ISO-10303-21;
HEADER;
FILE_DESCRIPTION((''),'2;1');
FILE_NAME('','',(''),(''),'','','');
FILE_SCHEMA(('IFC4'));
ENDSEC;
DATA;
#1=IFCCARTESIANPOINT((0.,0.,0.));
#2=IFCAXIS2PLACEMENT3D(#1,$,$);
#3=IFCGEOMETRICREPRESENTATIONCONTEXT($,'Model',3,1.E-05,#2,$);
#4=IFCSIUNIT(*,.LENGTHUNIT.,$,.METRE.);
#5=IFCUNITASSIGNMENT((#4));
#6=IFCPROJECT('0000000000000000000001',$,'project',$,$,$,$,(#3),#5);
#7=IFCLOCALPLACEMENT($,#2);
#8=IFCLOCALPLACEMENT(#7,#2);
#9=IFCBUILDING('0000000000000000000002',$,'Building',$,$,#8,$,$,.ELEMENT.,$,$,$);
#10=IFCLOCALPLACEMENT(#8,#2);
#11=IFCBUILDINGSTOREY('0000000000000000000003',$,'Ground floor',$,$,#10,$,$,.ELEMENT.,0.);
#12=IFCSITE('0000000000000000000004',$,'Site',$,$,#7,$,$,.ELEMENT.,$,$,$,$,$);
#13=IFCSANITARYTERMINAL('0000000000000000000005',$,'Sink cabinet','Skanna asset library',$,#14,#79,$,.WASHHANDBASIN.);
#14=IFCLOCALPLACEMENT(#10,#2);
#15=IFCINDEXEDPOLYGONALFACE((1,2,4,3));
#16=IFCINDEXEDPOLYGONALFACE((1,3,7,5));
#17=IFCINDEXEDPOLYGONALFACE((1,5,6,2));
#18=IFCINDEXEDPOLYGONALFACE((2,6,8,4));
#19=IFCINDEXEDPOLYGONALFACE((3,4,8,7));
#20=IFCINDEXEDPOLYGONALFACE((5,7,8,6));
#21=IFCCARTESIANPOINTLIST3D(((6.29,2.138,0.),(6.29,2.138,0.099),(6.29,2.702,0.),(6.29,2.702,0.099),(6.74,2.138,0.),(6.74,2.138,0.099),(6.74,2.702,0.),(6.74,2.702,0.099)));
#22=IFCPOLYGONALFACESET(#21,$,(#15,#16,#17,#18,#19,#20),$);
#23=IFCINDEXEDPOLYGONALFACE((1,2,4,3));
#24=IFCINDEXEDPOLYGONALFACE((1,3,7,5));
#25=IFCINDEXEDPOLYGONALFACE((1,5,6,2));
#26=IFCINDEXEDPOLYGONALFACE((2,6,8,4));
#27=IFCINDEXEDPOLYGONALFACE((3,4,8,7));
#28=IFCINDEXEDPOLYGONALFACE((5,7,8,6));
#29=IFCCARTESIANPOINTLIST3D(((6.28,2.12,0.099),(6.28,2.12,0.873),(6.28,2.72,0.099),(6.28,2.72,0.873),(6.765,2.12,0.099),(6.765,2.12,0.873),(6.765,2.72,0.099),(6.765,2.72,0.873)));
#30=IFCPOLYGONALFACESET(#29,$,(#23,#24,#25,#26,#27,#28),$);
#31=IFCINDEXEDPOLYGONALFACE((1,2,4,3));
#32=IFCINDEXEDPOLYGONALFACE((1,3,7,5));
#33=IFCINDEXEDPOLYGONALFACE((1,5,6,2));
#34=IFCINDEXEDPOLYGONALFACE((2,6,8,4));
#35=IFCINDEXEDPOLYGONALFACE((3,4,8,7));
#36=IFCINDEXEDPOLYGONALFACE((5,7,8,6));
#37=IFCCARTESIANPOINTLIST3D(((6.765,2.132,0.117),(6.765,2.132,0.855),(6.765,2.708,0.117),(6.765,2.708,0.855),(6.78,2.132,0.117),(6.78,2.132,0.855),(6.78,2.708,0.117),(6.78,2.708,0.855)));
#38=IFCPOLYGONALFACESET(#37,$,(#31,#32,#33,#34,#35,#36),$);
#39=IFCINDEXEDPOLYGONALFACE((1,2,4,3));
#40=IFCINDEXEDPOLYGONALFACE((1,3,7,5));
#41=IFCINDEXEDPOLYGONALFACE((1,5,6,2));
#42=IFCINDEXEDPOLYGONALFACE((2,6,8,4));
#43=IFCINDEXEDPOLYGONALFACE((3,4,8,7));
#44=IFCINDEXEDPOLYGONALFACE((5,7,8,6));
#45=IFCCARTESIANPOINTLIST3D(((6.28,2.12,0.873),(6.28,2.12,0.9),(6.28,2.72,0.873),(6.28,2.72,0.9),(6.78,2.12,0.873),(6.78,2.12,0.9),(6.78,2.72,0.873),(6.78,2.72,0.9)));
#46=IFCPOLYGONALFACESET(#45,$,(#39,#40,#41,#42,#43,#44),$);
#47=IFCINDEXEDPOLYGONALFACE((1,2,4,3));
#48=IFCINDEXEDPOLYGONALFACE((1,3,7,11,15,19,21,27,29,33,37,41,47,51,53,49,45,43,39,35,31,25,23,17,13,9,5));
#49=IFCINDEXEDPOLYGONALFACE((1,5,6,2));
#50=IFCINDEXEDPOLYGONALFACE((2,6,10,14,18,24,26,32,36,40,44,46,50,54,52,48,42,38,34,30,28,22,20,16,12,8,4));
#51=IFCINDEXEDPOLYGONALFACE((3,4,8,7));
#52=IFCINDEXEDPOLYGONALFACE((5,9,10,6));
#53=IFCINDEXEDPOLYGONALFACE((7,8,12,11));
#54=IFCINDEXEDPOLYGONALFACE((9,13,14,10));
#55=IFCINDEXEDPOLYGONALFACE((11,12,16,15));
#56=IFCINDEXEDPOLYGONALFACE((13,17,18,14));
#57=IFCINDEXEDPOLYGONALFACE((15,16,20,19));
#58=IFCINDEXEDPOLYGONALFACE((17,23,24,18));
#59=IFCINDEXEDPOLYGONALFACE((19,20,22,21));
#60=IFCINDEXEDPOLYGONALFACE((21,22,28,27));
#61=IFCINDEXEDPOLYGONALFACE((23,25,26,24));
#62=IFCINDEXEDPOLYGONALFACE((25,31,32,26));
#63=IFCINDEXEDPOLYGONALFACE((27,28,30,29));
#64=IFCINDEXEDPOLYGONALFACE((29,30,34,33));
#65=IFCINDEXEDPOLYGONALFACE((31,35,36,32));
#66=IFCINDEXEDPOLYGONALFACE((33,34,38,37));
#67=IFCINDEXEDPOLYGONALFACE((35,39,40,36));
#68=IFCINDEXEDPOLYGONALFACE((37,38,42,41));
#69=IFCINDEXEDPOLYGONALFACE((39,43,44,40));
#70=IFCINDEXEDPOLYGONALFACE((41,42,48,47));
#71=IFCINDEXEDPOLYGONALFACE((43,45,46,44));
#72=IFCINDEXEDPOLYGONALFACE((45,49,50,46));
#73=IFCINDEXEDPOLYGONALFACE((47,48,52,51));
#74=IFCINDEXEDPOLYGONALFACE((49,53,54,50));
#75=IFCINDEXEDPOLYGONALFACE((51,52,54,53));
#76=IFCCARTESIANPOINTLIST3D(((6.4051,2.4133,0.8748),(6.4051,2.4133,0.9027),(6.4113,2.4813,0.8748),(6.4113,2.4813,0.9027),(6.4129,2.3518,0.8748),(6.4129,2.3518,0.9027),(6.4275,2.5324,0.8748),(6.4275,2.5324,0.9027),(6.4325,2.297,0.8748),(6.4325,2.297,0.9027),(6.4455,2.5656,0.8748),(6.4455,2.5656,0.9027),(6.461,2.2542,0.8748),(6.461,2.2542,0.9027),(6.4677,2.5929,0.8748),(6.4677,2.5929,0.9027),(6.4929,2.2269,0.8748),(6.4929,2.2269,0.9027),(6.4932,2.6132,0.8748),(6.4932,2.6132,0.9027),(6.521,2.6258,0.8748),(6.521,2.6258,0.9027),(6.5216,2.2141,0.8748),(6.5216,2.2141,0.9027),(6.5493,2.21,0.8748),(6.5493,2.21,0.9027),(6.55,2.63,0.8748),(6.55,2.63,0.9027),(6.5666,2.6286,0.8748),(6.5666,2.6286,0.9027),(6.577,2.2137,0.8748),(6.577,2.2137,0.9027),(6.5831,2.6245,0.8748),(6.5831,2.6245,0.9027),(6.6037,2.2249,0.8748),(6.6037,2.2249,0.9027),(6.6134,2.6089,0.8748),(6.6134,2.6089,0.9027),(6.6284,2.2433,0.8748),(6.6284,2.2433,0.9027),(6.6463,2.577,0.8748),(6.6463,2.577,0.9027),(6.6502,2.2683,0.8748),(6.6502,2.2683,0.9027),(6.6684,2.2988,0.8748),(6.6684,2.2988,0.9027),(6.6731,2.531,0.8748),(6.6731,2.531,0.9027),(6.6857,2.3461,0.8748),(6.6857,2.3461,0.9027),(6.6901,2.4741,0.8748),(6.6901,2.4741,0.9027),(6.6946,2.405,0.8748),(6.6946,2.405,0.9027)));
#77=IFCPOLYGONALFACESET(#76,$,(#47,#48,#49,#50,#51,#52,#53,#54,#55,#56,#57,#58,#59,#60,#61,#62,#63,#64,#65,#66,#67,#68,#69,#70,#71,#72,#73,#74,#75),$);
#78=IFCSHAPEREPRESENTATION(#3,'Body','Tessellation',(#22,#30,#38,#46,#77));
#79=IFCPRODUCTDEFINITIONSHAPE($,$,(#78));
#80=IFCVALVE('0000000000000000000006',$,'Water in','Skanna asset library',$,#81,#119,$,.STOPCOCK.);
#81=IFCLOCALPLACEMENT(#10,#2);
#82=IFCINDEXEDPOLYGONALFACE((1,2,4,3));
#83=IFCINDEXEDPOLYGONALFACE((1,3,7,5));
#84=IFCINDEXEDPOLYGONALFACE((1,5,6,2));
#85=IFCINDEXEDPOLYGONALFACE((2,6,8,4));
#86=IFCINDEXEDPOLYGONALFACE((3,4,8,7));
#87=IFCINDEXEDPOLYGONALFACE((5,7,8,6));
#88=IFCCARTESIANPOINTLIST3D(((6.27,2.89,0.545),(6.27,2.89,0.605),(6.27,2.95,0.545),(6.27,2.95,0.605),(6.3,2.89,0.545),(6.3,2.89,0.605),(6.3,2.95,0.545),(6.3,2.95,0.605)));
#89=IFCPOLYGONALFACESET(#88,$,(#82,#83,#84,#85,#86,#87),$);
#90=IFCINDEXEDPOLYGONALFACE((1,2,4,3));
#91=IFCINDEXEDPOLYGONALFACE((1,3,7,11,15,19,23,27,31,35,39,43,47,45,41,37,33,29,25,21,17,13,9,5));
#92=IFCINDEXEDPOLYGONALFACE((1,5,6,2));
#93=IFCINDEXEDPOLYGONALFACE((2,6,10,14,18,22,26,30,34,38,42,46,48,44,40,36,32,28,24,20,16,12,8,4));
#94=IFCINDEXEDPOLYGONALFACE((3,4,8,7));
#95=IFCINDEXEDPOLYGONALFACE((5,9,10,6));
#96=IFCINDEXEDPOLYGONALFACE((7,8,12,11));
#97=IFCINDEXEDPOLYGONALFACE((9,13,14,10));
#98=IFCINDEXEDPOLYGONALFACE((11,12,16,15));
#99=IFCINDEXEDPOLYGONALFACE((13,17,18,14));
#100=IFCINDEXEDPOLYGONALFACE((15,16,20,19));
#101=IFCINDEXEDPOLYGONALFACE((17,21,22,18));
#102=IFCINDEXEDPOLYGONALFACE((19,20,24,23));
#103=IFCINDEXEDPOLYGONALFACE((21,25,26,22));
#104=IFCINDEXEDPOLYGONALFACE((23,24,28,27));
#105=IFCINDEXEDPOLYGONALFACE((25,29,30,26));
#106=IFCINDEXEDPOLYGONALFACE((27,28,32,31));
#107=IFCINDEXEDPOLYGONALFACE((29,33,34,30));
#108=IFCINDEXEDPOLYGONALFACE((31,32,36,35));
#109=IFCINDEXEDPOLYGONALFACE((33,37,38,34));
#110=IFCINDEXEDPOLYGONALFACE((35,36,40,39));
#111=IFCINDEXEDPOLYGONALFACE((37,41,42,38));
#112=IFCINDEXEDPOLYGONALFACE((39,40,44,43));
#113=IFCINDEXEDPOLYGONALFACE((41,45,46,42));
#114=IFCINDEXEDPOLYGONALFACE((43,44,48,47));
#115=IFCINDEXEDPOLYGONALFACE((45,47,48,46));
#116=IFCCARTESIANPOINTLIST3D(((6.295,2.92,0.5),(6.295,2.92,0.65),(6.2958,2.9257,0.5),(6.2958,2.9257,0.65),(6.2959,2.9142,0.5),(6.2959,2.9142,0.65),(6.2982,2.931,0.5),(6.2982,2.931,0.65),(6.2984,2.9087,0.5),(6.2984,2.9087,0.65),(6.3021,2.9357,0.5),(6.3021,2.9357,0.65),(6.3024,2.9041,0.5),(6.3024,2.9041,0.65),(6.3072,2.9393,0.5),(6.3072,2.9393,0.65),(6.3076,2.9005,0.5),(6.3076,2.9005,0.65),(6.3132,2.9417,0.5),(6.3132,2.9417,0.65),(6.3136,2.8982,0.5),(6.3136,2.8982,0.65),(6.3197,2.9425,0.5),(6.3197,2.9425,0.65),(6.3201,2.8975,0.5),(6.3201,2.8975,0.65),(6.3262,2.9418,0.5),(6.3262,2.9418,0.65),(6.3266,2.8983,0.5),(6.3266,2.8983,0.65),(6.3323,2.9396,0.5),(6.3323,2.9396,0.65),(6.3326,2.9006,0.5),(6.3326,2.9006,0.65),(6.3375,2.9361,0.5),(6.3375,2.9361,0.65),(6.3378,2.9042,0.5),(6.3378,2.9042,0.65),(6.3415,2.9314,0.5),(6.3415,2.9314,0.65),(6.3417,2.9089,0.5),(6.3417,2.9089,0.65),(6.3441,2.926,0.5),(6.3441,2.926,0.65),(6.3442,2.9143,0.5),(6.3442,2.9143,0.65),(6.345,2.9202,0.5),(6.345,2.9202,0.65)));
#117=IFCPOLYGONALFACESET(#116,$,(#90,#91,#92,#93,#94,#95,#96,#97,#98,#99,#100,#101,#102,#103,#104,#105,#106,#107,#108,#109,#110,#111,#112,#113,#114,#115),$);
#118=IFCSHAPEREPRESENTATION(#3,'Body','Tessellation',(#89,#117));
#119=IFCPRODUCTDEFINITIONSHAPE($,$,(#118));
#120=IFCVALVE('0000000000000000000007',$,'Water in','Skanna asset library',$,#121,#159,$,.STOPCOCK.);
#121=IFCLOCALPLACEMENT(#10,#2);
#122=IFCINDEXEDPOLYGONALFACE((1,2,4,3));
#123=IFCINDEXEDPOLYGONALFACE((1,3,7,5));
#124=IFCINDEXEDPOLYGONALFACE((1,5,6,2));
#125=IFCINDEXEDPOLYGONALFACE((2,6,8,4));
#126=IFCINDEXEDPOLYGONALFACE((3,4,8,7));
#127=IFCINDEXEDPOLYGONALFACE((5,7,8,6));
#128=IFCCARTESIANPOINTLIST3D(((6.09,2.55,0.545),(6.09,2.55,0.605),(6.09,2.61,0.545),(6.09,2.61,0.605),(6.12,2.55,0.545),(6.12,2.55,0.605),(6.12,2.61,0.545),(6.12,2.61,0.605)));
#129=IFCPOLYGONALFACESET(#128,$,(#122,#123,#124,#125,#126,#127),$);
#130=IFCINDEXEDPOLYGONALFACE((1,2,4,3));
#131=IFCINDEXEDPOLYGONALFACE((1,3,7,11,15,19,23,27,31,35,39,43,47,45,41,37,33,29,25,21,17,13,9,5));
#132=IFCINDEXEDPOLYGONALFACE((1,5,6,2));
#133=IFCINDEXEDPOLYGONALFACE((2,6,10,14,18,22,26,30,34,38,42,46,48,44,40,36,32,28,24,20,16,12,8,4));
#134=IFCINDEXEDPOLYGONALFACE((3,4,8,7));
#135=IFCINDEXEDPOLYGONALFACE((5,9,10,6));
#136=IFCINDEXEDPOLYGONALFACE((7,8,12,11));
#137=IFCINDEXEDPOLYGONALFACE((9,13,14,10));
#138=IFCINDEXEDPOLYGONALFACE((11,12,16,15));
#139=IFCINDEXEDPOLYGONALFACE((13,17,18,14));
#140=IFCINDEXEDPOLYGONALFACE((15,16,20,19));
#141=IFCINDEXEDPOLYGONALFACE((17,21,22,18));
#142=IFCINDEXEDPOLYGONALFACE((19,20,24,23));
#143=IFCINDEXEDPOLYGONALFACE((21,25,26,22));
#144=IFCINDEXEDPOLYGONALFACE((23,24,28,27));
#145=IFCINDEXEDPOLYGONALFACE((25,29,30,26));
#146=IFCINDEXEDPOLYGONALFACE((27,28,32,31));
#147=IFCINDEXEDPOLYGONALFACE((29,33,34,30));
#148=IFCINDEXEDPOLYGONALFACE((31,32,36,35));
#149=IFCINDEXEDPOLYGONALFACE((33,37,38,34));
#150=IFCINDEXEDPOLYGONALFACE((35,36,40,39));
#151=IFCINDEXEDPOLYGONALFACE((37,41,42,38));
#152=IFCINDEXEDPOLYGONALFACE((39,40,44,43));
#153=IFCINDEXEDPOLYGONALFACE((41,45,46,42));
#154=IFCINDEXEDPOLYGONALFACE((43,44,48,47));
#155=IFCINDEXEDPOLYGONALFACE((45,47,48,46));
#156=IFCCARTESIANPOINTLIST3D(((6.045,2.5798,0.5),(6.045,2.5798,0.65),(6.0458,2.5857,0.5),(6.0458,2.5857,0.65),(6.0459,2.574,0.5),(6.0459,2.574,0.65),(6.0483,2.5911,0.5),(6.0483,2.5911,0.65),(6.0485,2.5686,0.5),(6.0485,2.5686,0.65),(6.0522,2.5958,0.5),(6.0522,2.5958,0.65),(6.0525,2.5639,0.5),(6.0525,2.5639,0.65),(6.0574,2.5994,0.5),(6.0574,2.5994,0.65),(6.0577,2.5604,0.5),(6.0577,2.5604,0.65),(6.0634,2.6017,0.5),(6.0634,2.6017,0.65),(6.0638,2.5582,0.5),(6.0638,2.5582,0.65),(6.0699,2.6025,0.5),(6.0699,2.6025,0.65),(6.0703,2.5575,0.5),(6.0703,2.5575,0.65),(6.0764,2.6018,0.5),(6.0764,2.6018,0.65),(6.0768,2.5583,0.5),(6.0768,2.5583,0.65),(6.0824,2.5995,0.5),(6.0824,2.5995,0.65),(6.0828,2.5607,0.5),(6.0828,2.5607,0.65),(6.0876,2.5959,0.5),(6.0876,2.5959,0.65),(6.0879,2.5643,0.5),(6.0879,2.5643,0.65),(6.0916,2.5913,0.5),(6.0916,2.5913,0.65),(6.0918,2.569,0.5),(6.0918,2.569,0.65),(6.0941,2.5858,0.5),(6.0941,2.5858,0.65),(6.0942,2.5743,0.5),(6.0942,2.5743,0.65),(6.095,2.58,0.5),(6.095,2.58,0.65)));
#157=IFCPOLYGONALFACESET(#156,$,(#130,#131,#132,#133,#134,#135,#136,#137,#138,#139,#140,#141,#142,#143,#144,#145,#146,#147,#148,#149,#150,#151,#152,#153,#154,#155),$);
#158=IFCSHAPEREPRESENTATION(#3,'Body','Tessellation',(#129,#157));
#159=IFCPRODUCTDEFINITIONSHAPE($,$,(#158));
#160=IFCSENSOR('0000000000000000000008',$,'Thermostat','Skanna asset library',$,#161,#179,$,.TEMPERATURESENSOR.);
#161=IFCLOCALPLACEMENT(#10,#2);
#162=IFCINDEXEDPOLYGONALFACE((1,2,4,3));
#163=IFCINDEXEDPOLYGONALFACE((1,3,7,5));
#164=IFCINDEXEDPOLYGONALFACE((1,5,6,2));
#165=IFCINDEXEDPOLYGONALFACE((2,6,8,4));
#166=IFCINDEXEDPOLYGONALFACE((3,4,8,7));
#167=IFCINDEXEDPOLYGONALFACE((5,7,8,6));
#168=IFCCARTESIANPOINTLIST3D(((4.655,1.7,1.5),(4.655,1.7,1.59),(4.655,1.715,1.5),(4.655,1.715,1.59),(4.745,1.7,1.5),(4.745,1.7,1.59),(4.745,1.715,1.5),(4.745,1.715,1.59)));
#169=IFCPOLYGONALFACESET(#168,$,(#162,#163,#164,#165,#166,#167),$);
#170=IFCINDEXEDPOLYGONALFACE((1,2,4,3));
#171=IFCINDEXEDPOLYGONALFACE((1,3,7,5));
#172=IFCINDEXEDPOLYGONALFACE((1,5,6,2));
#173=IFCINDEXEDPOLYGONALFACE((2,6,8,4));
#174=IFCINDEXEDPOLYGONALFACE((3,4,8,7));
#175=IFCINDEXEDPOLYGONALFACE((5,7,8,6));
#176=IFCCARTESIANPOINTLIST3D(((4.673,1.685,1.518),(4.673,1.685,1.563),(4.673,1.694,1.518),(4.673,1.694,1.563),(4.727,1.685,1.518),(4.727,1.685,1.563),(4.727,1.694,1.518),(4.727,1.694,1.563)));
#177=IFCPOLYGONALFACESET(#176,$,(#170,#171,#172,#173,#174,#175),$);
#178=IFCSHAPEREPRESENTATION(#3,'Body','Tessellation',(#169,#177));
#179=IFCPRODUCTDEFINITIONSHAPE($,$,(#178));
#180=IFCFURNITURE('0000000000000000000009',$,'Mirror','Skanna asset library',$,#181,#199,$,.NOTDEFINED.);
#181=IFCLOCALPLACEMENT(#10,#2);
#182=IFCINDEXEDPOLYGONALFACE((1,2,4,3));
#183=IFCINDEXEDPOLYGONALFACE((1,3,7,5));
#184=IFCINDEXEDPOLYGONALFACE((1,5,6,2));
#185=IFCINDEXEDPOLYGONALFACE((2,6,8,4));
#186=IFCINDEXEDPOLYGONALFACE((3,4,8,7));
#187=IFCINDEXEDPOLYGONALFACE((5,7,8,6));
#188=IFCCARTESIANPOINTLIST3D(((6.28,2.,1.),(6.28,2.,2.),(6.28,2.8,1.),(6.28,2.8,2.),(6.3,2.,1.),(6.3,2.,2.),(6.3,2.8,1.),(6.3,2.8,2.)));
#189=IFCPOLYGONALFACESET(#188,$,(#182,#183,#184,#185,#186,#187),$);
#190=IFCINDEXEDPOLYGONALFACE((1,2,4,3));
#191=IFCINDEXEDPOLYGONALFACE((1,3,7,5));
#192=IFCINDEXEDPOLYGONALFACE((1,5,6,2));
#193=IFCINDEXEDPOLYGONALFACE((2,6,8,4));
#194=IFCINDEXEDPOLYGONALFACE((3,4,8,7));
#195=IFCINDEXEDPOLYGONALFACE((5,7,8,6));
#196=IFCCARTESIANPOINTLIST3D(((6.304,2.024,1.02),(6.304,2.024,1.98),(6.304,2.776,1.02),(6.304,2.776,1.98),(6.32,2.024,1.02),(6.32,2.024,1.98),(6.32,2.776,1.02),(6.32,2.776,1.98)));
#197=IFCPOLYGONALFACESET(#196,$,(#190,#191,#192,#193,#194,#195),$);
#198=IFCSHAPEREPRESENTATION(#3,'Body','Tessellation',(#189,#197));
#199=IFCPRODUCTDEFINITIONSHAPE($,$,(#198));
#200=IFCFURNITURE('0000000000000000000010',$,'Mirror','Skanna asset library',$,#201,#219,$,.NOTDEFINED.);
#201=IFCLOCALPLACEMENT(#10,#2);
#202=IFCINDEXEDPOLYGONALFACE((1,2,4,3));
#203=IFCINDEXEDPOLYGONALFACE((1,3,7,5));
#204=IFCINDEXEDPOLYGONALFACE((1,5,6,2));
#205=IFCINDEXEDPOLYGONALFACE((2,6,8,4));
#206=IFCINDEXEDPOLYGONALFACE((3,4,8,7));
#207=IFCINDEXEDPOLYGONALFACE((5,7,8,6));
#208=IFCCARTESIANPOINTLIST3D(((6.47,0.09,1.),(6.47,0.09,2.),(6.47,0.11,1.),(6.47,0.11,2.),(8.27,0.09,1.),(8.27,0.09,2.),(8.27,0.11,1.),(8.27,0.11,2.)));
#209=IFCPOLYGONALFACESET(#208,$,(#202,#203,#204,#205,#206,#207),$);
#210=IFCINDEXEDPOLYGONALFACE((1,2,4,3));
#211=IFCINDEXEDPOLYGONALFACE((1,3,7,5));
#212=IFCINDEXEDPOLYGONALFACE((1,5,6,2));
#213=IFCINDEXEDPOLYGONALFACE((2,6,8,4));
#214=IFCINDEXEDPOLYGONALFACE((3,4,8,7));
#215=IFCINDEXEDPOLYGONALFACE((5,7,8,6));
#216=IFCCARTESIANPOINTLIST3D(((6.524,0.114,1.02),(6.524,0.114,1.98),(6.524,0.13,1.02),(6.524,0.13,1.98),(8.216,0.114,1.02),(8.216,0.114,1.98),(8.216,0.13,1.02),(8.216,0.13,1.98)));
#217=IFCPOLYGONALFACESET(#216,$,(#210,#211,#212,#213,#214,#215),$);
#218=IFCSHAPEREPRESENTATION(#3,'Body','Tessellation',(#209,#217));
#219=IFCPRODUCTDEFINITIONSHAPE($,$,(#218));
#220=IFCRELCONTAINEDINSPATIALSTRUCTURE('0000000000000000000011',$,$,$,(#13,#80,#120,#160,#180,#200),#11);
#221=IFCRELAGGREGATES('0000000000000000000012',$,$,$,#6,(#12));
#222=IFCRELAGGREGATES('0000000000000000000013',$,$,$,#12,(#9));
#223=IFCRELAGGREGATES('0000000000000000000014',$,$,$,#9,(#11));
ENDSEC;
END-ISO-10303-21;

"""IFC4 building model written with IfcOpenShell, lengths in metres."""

from ifc_helpers import new_model, si_unit, frame, frame_2d, origin, origin_2d, place, context, project, spatial, rectangle, ellipse, extrude, element, save


model = new_model("IFC4")

# Units and contexts
model_context = context("Model", 3, precision=1e-05, world=origin())
ifc_project = project(units=[si_unit("LENGTHUNIT", "METRE")], contexts=[model_context])

# Site, building, storey
site_placement = place(None, origin())
site = spatial("IfcSite", under=ifc_project, at=site_placement, Name="Site", CompositionType="ELEMENT")
building_placement = place(site_placement, origin())
building = spatial("IfcBuilding", under=site, at=building_placement, Name="Building", CompositionType="ELEMENT")
storey_placement = place(building_placement, origin())
storey = spatial("IfcBuildingStorey", under=building, at=storey_placement, Name="Ground floor", CompositionType="ELEMENT", Elevation=0.0)

# Sanitary terminal
sanitary_terminal_1_placement = place(storey_placement, frame((6.53, 2.42, 0.0), z_axis=(0.0, 0.0, 1.0), x_axis=(0.0, 1.0, 0.0)))
element("IfcSanitaryTerminal", 1, at=sanitary_terminal_1_placement, inside=storey, Name="Sink cabinet", Description="Skanna asset library", PredefinedType="WASHHANDBASIN", context=model_context, shape_type="SweptSolid", body=[
    extrude(rectangle(XDim=0.564, YDim=0.45, at=frame_2d((0.0, 0.015))), origin(), (0.0, 0.0, 1.0), 0.099),
    extrude(rectangle(XDim=0.6, YDim=0.485, at=frame_2d((0.0, 0.0075))), frame((0.0, 0.0, 0.099)), (0.0, 0.0, 1.0), 0.774),
    extrude(rectangle(XDim=0.576, YDim=0.015, at=frame_2d((0.0, -0.2425))), frame((0.0, 0.0, 0.117)), (0.0, 0.0, 1.0), 0.738),
    extrude(rectangle(XDim=0.6, YDim=0.5, at=origin_2d()), frame((0.0, 0.0, 0.873)), (0.0, 0.0, 1.0), 0.027),
    extrude(ellipse(SemiAxis1=0.21, SemiAxis2=0.145, at=frame_2d((0.0, -0.02))), frame((0.0, 0.0, 0.8748)), (0.0, 0.0, 1.0), 0.0279),
])

# Valves
for number, where, z_axis, x_axis, name in (
    (2, (6.32, 2.92, 0.5), (0.0, 0.0, 1.0), (0.0, 1.0, 0.0), "Water in"),
    (3, (6.07, 2.58, 0.5), (0.0, 0.0, 1.0), (0.0, -1.0, 0.0), "Water in"),
):
    element("IfcValve", number, at=place(storey_placement, frame(where, z_axis=z_axis, x_axis=x_axis)), inside=storey, Name=name, Description="Skanna asset library", PredefinedType="STOPCOCK", context=model_context, shape_type="SweptSolid", body=[
        extrude(rectangle(XDim=0.06, YDim=0.03, at=frame_2d((0.0, 0.035))), frame((0.0, 0.0, 0.045)), (0.0, 0.0, 1.0), 0.06),
        extrude(ellipse(SemiAxis1=0.0225, SemiAxis2=0.025, at=origin_2d()), origin(), (0.0, 0.0, 1.0), 0.15),
    ])

# Sensor
sensor_placement = place(storey_placement, frame((4.7, 1.7, 1.5), z_axis=(0.0, 0.0, 1.0), x_axis=(1.0, 0.0, 0.0)))
element("IfcSensor", 4, at=sensor_placement, inside=storey, Name="Thermostat", Description="Skanna asset library", PredefinedType="TEMPERATURESENSOR", context=model_context, shape_type="SweptSolid", body=[
    extrude(rectangle(XDim=0.09, YDim=0.015, at=frame_2d((0.0, 0.0075))), origin(), (0.0, 0.0, 1.0), 0.09),
    extrude(rectangle(XDim=0.054, YDim=0.009, at=frame_2d((0.0, -0.0105))), frame((0.0, 0.0, 0.018)), (0.0, 0.0, 1.0), 0.045),
])

# Furniture
furniture_1_placement = place(storey_placement, frame((6.3, 2.4, 1.0), z_axis=(0.0, 0.0, 1.0), x_axis=(0.0, 1.0, 0.0)))
element("IfcFurniture", 5, at=furniture_1_placement, inside=storey, Name="Mirror", Description="Skanna asset library", PredefinedType="NOTDEFINED", context=model_context, shape_type="SweptSolid", body=[
    extrude(rectangle(XDim=0.8, YDim=0.02, at=frame_2d((0.0, 0.01))), origin(), (0.0, 0.0, 1.0), 1.0),
    extrude(rectangle(XDim=0.752, YDim=0.016, at=frame_2d((0.0, -0.012))), frame((0.0, 0.0, 0.02)), (0.0, 0.0, 1.0), 0.96),
])
furniture_2_placement = place(storey_placement, frame((7.37, 0.11, 1.0), z_axis=(0.0, 0.0, 1.0), x_axis=(-1.0, 0.0, 0.0)))
element("IfcFurniture", 6, at=furniture_2_placement, inside=storey, Name="Mirror", Description="Skanna asset library", PredefinedType="NOTDEFINED", context=model_context, shape_type="SweptSolid", body=[
    extrude(rectangle(XDim=1.8, YDim=0.02, at=frame_2d((0.0, 0.01))), origin(), (0.0, 0.0, 1.0), 1.0),
    extrude(rectangle(XDim=1.692, YDim=0.016, at=frame_2d((0.0, -0.012))), frame((0.0, 0.0, 0.02)), (0.0, 0.0, 1.0), 0.96),
])

save(model, "model.ifc")
